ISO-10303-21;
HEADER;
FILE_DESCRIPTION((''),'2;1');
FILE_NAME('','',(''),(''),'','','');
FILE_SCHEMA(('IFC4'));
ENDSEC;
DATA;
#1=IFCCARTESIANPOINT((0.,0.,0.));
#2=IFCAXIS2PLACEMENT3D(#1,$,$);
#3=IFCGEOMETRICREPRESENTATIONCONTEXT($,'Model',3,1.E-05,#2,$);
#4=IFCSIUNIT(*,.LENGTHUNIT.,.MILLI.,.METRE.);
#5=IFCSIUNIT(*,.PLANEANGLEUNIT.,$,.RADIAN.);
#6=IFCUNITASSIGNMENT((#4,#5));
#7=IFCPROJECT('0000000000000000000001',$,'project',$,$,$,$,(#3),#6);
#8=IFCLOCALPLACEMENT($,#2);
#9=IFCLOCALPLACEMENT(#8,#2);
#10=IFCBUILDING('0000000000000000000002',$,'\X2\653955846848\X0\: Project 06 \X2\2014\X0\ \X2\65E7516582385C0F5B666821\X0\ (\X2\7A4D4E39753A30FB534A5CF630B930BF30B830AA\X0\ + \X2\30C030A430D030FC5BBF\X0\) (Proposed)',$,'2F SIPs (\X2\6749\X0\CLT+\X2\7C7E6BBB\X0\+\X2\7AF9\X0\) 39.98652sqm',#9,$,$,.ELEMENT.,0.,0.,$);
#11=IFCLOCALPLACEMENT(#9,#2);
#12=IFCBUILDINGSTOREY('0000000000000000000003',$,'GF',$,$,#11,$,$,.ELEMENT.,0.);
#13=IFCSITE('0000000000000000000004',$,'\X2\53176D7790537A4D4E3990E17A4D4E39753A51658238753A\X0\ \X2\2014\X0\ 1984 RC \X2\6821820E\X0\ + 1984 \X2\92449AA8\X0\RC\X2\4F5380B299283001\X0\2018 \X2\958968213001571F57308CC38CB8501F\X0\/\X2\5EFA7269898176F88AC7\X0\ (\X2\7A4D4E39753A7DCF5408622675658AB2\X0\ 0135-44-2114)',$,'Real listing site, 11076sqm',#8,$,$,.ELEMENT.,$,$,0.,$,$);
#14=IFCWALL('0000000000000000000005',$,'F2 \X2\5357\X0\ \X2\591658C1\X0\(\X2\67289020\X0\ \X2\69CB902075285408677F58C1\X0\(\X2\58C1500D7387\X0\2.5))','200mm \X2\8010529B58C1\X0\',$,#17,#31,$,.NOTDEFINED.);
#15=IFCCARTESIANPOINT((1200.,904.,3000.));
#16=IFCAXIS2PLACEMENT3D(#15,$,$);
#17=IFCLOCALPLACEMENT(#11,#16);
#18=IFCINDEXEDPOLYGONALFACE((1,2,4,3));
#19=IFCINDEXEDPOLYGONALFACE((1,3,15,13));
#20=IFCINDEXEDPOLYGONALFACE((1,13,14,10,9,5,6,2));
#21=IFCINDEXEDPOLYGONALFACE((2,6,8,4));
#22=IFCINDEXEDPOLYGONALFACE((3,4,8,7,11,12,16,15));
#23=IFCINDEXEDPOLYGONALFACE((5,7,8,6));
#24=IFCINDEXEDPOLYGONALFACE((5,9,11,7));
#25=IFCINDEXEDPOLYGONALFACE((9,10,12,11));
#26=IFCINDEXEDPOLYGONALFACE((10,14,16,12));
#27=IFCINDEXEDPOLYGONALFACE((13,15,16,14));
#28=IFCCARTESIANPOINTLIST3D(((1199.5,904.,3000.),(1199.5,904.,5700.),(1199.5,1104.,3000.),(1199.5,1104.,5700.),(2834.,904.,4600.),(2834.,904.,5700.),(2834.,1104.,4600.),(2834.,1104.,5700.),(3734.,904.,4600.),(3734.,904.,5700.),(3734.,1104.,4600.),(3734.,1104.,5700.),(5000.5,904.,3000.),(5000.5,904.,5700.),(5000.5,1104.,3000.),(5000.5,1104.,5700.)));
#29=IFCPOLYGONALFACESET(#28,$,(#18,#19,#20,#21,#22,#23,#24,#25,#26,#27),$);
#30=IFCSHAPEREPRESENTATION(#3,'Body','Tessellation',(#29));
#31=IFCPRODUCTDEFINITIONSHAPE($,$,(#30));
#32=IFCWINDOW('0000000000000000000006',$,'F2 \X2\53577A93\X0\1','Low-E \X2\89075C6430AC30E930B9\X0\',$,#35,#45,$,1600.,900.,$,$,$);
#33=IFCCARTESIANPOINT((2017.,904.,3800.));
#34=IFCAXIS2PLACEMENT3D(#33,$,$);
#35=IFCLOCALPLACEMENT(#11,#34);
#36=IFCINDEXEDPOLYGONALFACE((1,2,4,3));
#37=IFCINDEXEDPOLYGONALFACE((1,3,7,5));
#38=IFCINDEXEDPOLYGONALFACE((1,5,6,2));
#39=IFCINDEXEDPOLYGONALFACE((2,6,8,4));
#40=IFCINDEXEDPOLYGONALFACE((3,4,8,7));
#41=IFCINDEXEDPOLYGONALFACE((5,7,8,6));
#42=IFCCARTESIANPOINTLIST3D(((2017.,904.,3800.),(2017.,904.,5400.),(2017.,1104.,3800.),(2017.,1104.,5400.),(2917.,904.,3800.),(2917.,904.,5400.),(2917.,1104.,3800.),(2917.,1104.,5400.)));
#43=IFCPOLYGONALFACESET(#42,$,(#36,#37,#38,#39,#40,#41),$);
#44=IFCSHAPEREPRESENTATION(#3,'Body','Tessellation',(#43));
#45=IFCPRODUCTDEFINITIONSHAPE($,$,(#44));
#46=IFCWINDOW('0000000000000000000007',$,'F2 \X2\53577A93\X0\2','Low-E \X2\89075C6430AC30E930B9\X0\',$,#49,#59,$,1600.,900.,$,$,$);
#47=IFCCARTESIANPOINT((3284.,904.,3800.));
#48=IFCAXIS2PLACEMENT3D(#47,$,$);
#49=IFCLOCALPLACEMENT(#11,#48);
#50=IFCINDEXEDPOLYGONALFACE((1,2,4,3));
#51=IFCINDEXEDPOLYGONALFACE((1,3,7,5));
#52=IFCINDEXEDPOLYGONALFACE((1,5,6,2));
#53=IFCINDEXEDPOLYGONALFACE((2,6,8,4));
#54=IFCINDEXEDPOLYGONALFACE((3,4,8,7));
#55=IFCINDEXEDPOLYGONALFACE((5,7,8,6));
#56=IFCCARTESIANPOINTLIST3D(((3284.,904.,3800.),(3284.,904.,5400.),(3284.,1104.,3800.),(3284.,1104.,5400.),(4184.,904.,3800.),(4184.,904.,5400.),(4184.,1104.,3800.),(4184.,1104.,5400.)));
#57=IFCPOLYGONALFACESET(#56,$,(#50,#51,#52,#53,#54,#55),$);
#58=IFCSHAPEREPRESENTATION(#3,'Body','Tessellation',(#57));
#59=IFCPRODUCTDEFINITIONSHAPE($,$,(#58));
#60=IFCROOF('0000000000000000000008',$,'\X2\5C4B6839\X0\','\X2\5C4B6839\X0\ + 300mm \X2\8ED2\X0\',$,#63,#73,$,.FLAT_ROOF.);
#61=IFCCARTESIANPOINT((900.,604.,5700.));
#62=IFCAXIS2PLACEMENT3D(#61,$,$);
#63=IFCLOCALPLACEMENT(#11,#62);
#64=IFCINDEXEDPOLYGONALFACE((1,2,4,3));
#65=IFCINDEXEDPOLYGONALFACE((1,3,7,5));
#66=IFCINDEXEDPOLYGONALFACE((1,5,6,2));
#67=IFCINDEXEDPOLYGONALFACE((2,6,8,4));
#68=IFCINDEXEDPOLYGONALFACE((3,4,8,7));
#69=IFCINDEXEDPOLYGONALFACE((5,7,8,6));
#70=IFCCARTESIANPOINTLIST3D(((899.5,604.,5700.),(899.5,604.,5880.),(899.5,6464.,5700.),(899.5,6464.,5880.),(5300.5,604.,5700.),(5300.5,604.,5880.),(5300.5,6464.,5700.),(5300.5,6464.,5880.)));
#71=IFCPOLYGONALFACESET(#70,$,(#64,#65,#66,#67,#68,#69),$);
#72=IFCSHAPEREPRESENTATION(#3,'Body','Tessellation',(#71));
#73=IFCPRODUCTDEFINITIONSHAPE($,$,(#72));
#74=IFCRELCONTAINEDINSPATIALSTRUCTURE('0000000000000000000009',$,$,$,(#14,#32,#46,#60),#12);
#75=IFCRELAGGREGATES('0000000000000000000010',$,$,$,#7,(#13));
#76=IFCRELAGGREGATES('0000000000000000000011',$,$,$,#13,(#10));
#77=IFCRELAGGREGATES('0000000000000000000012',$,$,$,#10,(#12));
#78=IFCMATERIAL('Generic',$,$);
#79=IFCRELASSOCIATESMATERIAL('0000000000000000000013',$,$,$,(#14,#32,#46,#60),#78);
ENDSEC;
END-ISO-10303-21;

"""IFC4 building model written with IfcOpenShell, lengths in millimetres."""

from ifc_helpers import new_model, si_unit, frame, frame_2d, origin, place, context, project, spatial, rectangle, extrude, material, element, fill, save


model = new_model("IFC4")

# Units and contexts
model_context = context("Model", 3, precision=1e-05, world=origin())
ifc_project = project(units=[si_unit("LENGTHUNIT", "METRE", prefix="MILLI"), si_unit("PLANEANGLEUNIT", "RADIAN")], contexts=[model_context])

# Site, building, storey
site_placement = place(None, origin())
site = spatial("IfcSite", under=ifc_project, at=site_placement, Name="北海道積丹郡積丹町入舸町 — 1984 RC 校舎 + 1984 鉄骨RC体育館、2018 閉校、土地賃貸借/建物要相談 (積丹町総合戦略課 0135-44-2114)", ObjectType="Real listing site, 11076sqm", CompositionType="ELEMENT", RefElevation=0.0)
building_placement = place(site_placement, origin())
building = spatial("IfcBuilding", under=site, at=building_placement, Name="改善案: Project 06 — 旧入舸小学校 (積丹町・半島スタジオ + ダイバー宿) (Proposed)", ObjectType="2F SIPs (杉CLT+籾殻+竹) 39.98652sqm", CompositionType="ELEMENT", ElevationOfRefHeight=0.0, ElevationOfTerrain=0.0)
storey_placement = place(building_placement, origin())
storey = spatial("IfcBuildingStorey", under=building, at=storey_placement, Name="GF", CompositionType="ELEMENT", Elevation=0.0)

# Shared definitions
ifc_material_1 = material(Name="Generic")

# Wall, openings, windows
wall_1_placement = place(storey_placement, frame((1200.0, 904.0, 3000.0)))
wall_1 = element("IfcWall", 1, at=wall_1_placement, inside=storey, material=ifc_material_1, Name="F2 南 外壁(木造 構造用合板壁(壁倍率2.5))", Description="200mm 耐力壁", PredefinedType="NOTDEFINED", context=model_context, shape_type="SweptSolid", body=[
    extrude(rectangle(XDim=3801.0, YDim=200.0, at=frame_2d((1900.0, 100.0))), frame((1200.0, 904.0, 3000.0)), (0.0, 0.0, 1.0), 2700.0),
])
opening_1_placement = place(storey_placement, frame((2017.0, 904.0, 3800.0)))
opening_1 = element("IfcOpeningElement", 2, at=opening_1_placement, cuts=wall_1, PredefinedType="NOTDEFINED", context=model_context, shape_type="SweptSolid", body=[
    extrude(rectangle(XDim=900.0, YDim=200.0, at=frame_2d((450.0, 100.0))), frame((2017.0, 904.0, 3800.0)), (0.0, 0.0, 1.0), 1600.0),
])
opening_2_placement = place(storey_placement, frame((3284.0, 904.0, 3800.0)))
opening_2 = element("IfcOpeningElement", 3, at=opening_2_placement, cuts=wall_1, PredefinedType="NOTDEFINED", context=model_context, shape_type="SweptSolid", body=[
    extrude(rectangle(XDim=900.0, YDim=200.0, at=frame_2d((450.0, 100.0))), frame((3284.0, 904.0, 3800.0)), (0.0, 0.0, 1.0), 1600.0),
])
window_1_placement = place(storey_placement, frame((2017.0, 904.0, 3800.0)))
window_1 = element("IfcWindow", 4, at=window_1_placement, inside=storey, material=ifc_material_1, Name="F2 南窓1", Description="Low-E 複層ガラス", OverallHeight=1600.0, OverallWidth=900.0, context=model_context, shape_type="SweptSolid", body=[
    extrude(rectangle(XDim=900.0, YDim=200.0, at=frame_2d((450.0, 100.0))), frame((2017.0, 904.0, 3800.0)), (0.0, 0.0, 1.0), 1600.0),
])
fill(opening_1, window_1)
window_2_placement = place(storey_placement, frame((3284.0, 904.0, 3800.0)))
window_2 = element("IfcWindow", 5, at=window_2_placement, inside=storey, material=ifc_material_1, Name="F2 南窓2", Description="Low-E 複層ガラス", OverallHeight=1600.0, OverallWidth=900.0, context=model_context, shape_type="SweptSolid", body=[
    extrude(rectangle(XDim=900.0, YDim=200.0, at=frame_2d((450.0, 100.0))), frame((3284.0, 904.0, 3800.0)), (0.0, 0.0, 1.0), 1600.0),
])
fill(opening_2, window_2)

# Roof
roof_placement = place(storey_placement, frame((900.0, 604.0, 5700.0)))
element("IfcRoof", 6, at=roof_placement, inside=storey, material=ifc_material_1, Name="屋根", Description="屋根 + 300mm 軒", PredefinedType="FLAT_ROOF", context=model_context, shape_type="SweptSolid", body=[
    extrude(rectangle(XDim=4401.0, YDim=5860.0, at=frame_2d((2200.0, 2930.0))), frame((900.0, 604.0, 5700.0)), (0.0, 0.0, 1.0), 180.0),
])

save(model, "model.ifc")
